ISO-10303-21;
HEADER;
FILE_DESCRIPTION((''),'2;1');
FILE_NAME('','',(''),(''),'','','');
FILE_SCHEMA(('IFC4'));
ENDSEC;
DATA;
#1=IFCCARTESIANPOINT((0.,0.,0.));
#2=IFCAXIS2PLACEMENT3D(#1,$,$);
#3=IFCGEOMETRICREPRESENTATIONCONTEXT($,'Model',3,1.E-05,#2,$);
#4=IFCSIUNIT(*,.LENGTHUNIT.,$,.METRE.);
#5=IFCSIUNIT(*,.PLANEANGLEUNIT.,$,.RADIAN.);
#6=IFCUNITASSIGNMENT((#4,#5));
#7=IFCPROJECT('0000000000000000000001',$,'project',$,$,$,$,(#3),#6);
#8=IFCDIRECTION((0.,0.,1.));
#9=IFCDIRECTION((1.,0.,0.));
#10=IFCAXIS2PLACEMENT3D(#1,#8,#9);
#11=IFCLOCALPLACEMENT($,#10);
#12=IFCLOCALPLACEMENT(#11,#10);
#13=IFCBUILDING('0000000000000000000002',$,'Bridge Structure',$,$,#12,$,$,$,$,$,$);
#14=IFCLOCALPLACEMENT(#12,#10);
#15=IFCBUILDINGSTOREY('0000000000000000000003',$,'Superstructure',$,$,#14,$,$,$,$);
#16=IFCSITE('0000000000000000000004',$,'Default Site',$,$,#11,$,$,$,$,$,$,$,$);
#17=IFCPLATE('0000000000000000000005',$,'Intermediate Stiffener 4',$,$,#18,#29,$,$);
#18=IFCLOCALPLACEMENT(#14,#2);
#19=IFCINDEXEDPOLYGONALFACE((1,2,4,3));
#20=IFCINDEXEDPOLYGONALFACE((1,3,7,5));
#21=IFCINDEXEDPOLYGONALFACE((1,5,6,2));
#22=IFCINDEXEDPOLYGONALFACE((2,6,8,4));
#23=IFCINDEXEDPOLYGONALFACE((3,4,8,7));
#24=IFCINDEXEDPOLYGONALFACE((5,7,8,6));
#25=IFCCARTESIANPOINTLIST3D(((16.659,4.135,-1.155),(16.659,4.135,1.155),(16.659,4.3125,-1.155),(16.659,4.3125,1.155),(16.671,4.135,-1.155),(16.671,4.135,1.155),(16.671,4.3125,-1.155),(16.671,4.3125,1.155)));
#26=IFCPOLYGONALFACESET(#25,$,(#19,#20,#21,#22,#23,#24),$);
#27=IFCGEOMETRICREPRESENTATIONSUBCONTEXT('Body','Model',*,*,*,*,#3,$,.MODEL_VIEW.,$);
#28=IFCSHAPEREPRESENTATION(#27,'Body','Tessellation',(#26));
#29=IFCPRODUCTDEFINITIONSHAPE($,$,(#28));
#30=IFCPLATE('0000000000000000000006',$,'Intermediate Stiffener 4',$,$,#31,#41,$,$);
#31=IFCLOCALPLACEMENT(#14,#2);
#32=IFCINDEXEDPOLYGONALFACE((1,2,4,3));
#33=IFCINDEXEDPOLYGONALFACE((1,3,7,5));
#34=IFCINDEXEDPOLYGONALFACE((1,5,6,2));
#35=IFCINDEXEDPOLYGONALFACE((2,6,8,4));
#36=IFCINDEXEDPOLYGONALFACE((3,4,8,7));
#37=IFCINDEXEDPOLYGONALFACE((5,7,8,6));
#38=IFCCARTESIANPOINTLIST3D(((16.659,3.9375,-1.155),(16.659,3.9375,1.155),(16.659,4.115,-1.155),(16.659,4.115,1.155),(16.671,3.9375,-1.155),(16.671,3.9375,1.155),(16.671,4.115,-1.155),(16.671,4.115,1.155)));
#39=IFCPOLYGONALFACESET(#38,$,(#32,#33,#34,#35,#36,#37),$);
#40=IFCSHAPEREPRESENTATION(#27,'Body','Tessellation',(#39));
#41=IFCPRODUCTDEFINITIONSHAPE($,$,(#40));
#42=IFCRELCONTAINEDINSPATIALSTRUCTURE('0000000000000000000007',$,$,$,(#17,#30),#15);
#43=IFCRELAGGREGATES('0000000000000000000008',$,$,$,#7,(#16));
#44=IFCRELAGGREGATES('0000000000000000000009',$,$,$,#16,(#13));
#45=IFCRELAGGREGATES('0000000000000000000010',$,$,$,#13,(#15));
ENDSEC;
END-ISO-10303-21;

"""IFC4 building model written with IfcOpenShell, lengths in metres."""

from ifc_helpers import new_model, si_unit, frame, origin, origin_with_axes, origin_2d_with_axis, place, context, subcontext, project, spatial, rectangle, extrude, element, save


model = new_model("IFC4")

# Units and contexts
model_context = context("Model", 3, precision=1e-05, world=origin())
body_context = subcontext(model_context, "Body", "Model", "MODEL_VIEW")
ifc_project = project(units=[si_unit("LENGTHUNIT", "METRE"), si_unit("PLANEANGLEUNIT", "RADIAN")], contexts=[model_context])

# Site, building, storey
site_placement = place(None, origin_with_axes())
site = spatial("IfcSite", under=ifc_project, at=site_placement, Name="Default Site")
building_placement = place(site_placement, origin_with_axes())
building = spatial("IfcBuilding", under=site, at=building_placement, Name="Bridge Structure")
storey_placement = place(building_placement, origin_with_axes())
storey = spatial("IfcBuildingStorey", under=building, at=storey_placement, Name="Superstructure")

# Plates
for number, where, z_axis, x_axis, name in (
    (1, (16.665, 4.2237, -1.155), (0.0, 0.0, 1.0), (1.0, 0.0, 0.0), "Intermediate Stiffener 4"),
    (2, (16.665, 4.0263, -1.155), (0.0, 0.0, 1.0), (1.0, 0.0, 0.0), "Intermediate Stiffener 4"),
):
    element("IfcPlate", number, at=place(storey_placement, frame(where, z_axis=z_axis, x_axis=x_axis)), inside=storey, Name=name, context=body_context, shape_type="SweptSolid", body=[
        extrude(rectangle(XDim=0.012, YDim=0.1775, at=origin_2d_with_axis()), origin_with_axes(), (0.0, 0.0, 1.0), 2.31),
    ])

save(model, "model.ifc")
